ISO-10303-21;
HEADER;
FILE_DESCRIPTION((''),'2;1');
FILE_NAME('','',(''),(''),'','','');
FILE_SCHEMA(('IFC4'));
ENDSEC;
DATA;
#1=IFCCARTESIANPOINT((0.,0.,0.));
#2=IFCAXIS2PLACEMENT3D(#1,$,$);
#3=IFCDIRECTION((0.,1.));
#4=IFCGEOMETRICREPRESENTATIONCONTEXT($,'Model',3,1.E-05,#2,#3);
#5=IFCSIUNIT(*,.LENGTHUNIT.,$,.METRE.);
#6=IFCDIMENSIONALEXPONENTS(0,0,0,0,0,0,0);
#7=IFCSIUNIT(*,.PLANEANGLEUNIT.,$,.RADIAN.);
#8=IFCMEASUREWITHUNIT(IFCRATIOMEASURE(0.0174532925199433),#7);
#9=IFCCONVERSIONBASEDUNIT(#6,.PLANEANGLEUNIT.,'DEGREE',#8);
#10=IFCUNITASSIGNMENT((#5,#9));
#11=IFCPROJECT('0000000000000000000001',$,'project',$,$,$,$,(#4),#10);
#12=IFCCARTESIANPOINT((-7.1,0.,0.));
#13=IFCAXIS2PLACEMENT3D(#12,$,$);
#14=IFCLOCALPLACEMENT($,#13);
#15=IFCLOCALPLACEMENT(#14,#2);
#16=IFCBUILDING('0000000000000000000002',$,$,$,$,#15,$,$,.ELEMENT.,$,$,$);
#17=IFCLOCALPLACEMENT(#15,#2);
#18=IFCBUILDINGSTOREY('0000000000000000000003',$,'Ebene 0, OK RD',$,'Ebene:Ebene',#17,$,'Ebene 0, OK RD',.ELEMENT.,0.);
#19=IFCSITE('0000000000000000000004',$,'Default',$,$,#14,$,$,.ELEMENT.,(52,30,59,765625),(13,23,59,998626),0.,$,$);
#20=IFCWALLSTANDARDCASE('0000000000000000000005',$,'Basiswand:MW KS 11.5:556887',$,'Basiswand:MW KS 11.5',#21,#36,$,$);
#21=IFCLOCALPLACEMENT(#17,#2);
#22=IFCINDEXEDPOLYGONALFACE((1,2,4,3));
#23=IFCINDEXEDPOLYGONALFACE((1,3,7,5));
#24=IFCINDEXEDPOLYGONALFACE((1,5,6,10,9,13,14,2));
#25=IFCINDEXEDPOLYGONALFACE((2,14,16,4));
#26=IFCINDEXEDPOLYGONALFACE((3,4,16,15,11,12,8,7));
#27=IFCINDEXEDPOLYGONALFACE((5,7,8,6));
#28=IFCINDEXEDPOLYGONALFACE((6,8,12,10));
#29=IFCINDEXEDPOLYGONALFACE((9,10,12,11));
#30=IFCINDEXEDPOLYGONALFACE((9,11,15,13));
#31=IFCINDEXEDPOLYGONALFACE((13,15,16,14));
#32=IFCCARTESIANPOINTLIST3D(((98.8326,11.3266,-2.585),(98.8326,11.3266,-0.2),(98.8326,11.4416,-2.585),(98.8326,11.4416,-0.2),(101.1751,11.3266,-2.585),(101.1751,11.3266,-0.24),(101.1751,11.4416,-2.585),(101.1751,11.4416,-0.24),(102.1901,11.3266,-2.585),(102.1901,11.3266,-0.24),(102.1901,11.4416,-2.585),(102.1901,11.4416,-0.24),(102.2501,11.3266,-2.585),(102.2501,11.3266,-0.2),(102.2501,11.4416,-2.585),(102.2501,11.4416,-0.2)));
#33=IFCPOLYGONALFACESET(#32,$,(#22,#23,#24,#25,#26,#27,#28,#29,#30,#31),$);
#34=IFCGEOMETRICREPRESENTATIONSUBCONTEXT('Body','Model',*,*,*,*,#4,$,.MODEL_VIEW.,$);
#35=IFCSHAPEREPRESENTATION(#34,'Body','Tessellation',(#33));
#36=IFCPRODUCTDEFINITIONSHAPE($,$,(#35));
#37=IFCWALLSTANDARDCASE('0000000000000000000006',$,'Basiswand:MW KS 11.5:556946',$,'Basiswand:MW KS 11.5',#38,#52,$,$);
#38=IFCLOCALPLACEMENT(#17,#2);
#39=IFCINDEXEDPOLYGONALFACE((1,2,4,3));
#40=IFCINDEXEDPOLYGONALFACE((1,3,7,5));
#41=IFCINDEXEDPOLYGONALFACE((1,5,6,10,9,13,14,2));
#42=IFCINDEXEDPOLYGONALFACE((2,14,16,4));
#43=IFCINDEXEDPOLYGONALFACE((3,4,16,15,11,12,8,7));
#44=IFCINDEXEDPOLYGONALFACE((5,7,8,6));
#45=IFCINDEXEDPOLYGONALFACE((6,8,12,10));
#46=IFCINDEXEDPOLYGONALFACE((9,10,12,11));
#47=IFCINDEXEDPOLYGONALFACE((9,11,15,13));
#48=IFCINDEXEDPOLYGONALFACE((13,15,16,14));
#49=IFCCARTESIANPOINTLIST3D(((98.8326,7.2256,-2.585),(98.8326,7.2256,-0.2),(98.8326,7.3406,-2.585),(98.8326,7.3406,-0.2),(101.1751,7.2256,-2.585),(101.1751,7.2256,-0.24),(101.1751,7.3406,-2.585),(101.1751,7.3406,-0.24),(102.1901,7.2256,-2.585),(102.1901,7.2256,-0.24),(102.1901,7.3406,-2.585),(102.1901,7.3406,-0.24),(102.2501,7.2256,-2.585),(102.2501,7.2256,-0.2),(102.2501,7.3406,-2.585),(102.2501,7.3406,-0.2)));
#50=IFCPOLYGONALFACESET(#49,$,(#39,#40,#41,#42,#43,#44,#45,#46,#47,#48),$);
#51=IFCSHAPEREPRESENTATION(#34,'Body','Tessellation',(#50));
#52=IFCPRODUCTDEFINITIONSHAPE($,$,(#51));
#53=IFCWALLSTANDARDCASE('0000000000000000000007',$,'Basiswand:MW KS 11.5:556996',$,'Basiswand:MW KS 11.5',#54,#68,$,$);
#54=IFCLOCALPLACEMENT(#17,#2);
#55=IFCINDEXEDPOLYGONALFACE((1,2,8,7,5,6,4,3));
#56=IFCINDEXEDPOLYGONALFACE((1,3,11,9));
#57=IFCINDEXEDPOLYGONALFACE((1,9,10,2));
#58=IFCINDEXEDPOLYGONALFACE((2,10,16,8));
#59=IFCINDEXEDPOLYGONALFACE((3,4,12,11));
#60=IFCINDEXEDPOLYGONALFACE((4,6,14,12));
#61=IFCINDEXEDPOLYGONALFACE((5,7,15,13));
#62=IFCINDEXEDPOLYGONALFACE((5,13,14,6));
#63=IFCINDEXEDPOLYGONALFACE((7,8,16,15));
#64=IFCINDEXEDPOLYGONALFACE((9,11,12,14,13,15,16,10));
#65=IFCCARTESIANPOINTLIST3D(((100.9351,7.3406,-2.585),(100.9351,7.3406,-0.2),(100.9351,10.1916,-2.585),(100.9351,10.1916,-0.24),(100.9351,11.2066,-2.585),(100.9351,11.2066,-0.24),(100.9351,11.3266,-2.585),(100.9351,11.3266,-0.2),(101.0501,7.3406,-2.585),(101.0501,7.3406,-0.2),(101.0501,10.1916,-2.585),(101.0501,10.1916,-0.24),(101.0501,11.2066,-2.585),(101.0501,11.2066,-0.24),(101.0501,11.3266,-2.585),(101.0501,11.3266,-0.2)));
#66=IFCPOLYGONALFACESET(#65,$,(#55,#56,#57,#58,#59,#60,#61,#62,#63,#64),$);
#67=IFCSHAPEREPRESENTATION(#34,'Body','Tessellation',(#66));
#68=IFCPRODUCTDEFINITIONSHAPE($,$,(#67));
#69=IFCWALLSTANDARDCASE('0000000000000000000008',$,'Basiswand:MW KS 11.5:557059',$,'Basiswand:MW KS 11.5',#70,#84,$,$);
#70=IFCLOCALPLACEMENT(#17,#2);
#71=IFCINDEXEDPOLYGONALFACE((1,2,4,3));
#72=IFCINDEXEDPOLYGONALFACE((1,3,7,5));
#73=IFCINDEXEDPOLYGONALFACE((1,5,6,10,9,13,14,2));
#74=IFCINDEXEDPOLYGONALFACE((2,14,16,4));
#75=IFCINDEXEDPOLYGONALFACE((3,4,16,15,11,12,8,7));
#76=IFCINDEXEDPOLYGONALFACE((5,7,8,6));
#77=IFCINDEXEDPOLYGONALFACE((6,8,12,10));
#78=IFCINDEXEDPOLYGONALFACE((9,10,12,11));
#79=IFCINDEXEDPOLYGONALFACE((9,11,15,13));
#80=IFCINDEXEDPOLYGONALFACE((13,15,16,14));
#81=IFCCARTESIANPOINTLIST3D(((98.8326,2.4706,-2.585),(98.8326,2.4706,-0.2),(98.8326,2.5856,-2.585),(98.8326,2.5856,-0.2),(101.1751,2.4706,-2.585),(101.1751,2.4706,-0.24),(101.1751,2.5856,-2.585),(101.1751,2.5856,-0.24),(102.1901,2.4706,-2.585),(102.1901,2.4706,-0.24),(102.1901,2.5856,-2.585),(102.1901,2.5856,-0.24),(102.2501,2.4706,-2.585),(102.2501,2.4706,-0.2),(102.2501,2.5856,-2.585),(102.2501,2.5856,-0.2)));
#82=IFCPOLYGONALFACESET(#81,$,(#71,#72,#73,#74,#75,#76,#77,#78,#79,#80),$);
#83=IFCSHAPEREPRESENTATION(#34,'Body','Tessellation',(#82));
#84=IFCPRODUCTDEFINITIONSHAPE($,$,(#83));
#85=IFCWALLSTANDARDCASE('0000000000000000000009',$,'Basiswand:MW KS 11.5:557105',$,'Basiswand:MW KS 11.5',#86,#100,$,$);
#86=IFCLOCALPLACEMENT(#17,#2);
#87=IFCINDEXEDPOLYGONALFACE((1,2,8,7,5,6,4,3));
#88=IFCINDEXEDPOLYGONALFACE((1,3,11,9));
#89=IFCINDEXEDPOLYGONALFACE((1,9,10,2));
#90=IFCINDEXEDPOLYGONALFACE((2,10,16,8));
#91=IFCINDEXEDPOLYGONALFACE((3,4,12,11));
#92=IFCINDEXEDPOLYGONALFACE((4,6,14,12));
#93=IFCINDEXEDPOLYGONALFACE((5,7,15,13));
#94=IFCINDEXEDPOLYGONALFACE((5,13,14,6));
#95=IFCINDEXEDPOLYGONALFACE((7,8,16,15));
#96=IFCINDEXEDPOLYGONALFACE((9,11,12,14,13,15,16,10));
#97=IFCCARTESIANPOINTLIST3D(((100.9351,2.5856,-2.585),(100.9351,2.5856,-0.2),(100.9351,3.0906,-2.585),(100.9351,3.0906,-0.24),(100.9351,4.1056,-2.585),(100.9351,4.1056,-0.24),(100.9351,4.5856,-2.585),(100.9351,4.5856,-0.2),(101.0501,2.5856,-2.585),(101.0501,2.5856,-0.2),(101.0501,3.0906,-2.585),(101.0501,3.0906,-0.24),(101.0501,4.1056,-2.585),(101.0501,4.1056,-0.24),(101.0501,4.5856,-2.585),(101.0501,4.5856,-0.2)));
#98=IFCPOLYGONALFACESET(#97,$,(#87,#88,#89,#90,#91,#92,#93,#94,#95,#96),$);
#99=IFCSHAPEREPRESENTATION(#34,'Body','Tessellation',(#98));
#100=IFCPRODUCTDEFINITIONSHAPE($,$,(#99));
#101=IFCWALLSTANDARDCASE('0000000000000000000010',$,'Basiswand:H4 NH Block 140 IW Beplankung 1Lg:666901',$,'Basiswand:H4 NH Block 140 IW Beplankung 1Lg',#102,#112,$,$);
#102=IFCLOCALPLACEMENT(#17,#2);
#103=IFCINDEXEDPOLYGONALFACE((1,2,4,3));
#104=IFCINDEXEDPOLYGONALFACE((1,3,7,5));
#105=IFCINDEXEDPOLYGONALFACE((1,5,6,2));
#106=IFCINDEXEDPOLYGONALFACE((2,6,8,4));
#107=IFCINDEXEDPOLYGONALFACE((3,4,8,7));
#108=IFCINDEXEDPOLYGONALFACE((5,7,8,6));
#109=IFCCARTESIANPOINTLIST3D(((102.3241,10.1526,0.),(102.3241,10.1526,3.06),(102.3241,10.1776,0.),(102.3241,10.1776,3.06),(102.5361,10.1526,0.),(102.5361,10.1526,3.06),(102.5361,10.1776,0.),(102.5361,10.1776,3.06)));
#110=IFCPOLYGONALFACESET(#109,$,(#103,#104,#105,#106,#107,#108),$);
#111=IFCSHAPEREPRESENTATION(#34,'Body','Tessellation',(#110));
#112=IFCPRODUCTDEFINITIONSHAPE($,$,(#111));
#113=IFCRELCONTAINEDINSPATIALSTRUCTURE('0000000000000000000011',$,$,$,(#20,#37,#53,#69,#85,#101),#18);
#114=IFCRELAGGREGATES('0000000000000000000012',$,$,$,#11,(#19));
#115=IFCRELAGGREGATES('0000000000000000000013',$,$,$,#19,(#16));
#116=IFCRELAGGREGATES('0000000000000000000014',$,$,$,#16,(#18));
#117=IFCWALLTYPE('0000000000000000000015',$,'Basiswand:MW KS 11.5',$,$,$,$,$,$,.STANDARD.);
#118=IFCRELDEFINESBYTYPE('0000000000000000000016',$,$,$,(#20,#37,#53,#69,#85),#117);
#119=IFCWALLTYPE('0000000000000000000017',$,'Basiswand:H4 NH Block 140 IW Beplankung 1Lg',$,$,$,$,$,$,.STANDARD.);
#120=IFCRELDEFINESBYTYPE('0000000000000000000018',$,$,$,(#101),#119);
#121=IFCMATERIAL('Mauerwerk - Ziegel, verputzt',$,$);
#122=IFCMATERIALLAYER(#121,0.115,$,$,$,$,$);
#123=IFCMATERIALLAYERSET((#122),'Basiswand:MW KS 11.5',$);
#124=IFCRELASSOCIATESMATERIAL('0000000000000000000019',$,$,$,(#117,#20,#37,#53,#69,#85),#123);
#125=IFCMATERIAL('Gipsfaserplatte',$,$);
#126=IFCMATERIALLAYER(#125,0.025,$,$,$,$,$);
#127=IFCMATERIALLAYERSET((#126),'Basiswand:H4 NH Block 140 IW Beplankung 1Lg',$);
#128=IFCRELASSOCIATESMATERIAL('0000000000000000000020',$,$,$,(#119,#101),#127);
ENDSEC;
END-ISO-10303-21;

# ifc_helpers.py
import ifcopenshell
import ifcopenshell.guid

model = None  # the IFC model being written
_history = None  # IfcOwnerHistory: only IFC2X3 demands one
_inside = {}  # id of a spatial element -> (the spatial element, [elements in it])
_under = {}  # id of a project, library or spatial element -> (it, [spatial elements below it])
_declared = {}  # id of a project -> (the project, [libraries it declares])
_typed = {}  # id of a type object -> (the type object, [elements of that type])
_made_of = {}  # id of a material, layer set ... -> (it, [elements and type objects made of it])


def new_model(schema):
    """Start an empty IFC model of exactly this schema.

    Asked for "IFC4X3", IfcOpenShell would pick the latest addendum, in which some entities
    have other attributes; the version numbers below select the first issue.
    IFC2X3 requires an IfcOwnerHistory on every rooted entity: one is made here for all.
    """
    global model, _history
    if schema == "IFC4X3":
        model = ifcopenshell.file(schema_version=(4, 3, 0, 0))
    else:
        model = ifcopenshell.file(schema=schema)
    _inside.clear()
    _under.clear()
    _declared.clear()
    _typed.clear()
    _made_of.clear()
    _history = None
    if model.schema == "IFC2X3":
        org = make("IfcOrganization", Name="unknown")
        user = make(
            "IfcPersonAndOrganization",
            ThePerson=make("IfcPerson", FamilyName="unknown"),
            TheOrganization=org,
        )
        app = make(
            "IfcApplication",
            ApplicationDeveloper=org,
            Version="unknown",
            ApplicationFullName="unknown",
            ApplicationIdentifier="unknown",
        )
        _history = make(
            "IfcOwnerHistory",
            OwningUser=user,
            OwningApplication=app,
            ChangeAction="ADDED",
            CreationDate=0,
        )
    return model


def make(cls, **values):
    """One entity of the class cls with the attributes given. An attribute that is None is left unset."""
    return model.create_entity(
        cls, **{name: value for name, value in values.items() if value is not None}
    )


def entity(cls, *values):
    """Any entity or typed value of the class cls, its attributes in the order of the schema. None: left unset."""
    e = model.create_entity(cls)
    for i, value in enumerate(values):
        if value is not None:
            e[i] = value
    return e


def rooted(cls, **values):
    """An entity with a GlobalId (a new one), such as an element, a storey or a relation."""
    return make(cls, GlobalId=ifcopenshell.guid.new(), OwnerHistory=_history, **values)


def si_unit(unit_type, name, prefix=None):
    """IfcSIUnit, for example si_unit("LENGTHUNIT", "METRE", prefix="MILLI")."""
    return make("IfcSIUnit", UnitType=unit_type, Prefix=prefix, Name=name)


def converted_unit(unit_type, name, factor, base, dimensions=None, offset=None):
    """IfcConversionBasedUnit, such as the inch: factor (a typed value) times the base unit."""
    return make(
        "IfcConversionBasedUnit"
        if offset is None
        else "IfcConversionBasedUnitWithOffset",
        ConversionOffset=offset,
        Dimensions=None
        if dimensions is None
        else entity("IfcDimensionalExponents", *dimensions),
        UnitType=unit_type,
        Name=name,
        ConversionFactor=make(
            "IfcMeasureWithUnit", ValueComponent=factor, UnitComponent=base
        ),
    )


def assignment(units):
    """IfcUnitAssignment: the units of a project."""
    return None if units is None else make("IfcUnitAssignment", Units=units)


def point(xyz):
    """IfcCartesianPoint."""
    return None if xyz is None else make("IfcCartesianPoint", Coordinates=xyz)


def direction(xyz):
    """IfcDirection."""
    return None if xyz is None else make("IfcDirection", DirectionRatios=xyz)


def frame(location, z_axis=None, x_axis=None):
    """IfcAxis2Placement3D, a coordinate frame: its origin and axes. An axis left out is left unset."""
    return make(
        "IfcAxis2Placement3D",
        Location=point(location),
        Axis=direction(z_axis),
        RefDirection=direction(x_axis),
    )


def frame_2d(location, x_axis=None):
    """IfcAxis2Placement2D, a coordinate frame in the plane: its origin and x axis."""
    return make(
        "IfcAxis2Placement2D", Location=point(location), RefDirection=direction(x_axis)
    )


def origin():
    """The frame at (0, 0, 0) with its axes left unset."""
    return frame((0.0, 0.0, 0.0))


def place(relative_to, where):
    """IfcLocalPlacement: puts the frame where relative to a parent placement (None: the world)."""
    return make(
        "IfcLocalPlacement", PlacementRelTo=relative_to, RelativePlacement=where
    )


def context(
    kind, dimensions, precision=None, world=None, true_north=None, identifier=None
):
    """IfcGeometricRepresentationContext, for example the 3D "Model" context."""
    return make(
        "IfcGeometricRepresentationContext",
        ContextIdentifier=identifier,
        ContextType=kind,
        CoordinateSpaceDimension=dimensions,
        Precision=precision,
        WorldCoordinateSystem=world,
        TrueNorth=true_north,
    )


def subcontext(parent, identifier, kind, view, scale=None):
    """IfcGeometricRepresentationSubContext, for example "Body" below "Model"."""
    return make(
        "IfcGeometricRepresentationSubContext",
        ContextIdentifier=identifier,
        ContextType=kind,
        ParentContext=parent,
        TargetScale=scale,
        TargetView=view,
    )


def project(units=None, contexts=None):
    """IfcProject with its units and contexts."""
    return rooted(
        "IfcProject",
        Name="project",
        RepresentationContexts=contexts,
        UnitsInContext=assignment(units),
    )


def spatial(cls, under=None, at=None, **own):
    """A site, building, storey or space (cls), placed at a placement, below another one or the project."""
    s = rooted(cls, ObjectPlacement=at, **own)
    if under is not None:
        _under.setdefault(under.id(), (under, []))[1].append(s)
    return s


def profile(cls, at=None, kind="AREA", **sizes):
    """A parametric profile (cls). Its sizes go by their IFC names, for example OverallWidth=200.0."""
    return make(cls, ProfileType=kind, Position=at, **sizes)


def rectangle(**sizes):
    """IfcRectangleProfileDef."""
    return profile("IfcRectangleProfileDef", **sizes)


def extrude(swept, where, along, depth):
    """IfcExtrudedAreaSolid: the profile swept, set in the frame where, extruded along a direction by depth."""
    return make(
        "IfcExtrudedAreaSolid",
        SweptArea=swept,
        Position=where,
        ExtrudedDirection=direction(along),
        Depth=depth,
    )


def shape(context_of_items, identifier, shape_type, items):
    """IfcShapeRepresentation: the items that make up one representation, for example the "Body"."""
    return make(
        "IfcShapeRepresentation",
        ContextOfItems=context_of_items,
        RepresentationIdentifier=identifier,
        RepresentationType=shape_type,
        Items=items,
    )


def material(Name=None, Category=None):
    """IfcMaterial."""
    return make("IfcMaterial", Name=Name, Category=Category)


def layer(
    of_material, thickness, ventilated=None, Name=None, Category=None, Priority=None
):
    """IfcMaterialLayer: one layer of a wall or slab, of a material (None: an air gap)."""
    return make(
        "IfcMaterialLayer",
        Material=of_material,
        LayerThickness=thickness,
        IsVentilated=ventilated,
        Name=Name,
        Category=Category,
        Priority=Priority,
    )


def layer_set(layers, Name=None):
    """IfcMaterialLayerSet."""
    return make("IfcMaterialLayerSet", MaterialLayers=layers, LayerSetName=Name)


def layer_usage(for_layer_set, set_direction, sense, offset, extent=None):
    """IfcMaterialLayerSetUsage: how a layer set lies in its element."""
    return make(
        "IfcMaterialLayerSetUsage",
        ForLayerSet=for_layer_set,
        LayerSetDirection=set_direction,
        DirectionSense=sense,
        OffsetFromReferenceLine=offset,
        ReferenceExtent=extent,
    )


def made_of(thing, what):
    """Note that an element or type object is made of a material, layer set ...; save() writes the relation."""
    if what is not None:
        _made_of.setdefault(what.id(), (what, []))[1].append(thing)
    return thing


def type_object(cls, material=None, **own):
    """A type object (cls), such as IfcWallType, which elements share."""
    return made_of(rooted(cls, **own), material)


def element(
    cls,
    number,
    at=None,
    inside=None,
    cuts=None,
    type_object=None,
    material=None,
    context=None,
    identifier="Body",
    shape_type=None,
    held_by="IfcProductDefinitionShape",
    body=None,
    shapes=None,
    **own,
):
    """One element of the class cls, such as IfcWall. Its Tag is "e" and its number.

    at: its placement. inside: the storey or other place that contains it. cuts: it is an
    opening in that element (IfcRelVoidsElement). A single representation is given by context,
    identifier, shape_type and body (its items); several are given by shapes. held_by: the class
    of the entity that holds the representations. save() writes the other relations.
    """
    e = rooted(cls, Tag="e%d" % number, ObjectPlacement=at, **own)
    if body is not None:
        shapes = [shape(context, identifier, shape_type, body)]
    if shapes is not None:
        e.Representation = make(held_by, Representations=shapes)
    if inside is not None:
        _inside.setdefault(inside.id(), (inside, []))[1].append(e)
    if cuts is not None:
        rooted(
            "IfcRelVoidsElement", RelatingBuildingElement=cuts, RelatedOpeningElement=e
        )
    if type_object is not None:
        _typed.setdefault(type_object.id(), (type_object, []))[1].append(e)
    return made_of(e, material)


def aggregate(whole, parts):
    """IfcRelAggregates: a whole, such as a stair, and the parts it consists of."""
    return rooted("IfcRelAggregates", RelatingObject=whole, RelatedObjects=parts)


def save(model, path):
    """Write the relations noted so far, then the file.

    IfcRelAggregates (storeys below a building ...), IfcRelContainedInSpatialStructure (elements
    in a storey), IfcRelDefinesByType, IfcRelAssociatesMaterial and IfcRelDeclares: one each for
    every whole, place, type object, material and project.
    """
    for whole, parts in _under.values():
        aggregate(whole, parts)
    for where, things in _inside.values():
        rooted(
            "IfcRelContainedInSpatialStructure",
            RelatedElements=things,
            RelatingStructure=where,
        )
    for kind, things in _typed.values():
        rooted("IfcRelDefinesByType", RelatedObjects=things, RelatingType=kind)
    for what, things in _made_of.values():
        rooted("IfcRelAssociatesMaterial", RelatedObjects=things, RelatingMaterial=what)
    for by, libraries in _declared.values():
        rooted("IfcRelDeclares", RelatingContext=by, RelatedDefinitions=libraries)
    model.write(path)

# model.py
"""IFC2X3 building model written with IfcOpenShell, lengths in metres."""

from ifc_helpers import new_model, entity, si_unit, converted_unit, direction, frame, frame_2d, origin, place, context, subcontext, project, spatial, rectangle, extrude, material, layer, layer_set, layer_usage, type_object, element, save


model = new_model("IFC2X3")

# Units and contexts
model_context = context("Model", 3, precision=1e-05, world=origin(), true_north=direction((0.0, 1.0)))
body_context = subcontext(model_context, "Body", "Model", "MODEL_VIEW")
ifc_project = project(units=[si_unit("LENGTHUNIT", "METRE"), converted_unit("PLANEANGLEUNIT", "DEGREE", entity("IfcRatioMeasure", 0.0174532925199433), si_unit("PLANEANGLEUNIT", "RADIAN"), dimensions=[0, 0, 0, 0, 0, 0, 0])], contexts=[model_context])

# Site, building, storey
site_placement = place(None, frame((-7.1, 0.0, 0.0)))
site = spatial("IfcSite", under=ifc_project, at=site_placement, Name="Default", CompositionType="ELEMENT", RefLatitude=(52, 30, 59, 765625), RefLongitude=(13, 23, 59, 998626), RefElevation=0.0)
building_placement = place(site_placement, origin())
building = spatial("IfcBuilding", under=site, at=building_placement, CompositionType="ELEMENT")
storey_placement = place(building_placement, origin())
storey = spatial("IfcBuildingStorey", under=building, at=storey_placement, Name="Ebene 0, OK RD", ObjectType="Ebene:Ebene", LongName="Ebene 0, OK RD", CompositionType="ELEMENT", Elevation=0.0)

# Shared definitions
ifc_material_1 = material(Name="Gipsfaserplatte")

# Walls, openings
ifc_material_2 = material(Name="Mauerwerk - Ziegel, verputzt")
ifc_layer_1 = layer(ifc_material_2, 0.115)
ifc_layer_set_1 = layer_set([ifc_layer_1], Name="Basiswand:MW KS 11.5")
ifc_layer_usage_1 = layer_usage(ifc_layer_set_1, "AXIS2", "NEGATIVE", 0.0575)
wall_type_1 = type_object("IfcWallType", Name="Basiswand:MW KS 11.5", PredefinedType="STANDARD", material=ifc_layer_set_1)
wall_1_placement = place(storey_placement, frame((102.2501, 11.3841, -2.585), z_axis=(0.0, 0.0, 1.0), x_axis=(-1.0, 0.0, 0.0)))
wall_1 = element("IfcWallStandardCase", 1, at=wall_1_placement, inside=storey, type_object=wall_type_1, material=ifc_layer_usage_1, Name="Basiswand:MW KS 11.5:556887", ObjectType="Basiswand:MW KS 11.5", context=body_context, shape_type="SweptSolid", body=[
    extrude(rectangle(XDim=3.4175, YDim=0.115, at=frame_2d((1.7087, 0.0), x_axis=(-1.0, 0.0))), origin(), (0.0, 0.0, 1.0), 2.385),
])
opening_1_placement = place(wall_1_placement, frame((1.075, 0.0575, 0.0)))
element("IfcOpeningElement", 2, at=opening_1_placement, cuts=wall_1, ObjectType="Opening", context=body_context, shape_type="SweptSolid", body=[
    extrude(rectangle(XDim=2.345, YDim=1.015, at=frame_2d((1.1725, 0.5075), x_axis=(1.0, 0.0))), frame((0.0, 0.0, 0.0), z_axis=(0.0, -1.0, 0.0), x_axis=(0.0, 0.0, 1.0)), (0.0, 0.0, 1.0), 0.115),
])
ifc_layer_usage_2 = layer_usage(ifc_layer_set_1, "AXIS2", "NEGATIVE", 0.0575)
wall_2_placement = place(storey_placement, frame((102.2501, 7.2831, -2.585), z_axis=(0.0, 0.0, 1.0), x_axis=(-1.0, 0.0, 0.0)))
wall_2 = element("IfcWallStandardCase", 3, at=wall_2_placement, inside=storey, type_object=wall_type_1, material=ifc_layer_usage_2, Name="Basiswand:MW KS 11.5:556946", ObjectType="Basiswand:MW KS 11.5", context=body_context, shape_type="SweptSolid", body=[
    extrude(rectangle(XDim=3.4175, YDim=0.115, at=frame_2d((1.7087, 0.0), x_axis=(-1.0, 0.0))), origin(), (0.0, 0.0, 1.0), 2.385),
])
opening_2_placement = place(wall_2_placement, frame((0.06, -0.0575, 0.0)))
element("IfcOpeningElement", 4, at=opening_2_placement, cuts=wall_2, ObjectType="Opening", context=body_context, shape_type="SweptSolid", body=[
    extrude(rectangle(XDim=2.345, YDim=1.015, at=frame_2d((1.1725, 0.5075), x_axis=(1.0, 0.0))), frame((0.0, 0.0, 0.0), z_axis=(0.0, 1.0, 0.0), x_axis=(0.0, 0.0, 1.0)), (0.0, 0.0, 1.0), 0.115),
])
ifc_layer_usage_3 = layer_usage(ifc_layer_set_1, "AXIS2", "NEGATIVE", 0.0575)
wall_3_placement = place(storey_placement, frame((100.9926, 7.3406, -2.585), z_axis=(0.0, 0.0, 1.0), x_axis=(0.0, 1.0, 0.0)))
wall_3 = element("IfcWallStandardCase", 5, at=wall_3_placement, inside=storey, type_object=wall_type_1, material=ifc_layer_usage_3, Name="Basiswand:MW KS 11.5:556996", ObjectType="Basiswand:MW KS 11.5", context=body_context, shape_type="SweptSolid", body=[
    extrude(rectangle(XDim=3.986, YDim=0.115, at=frame_2d((1.993, 0.0), x_axis=(-1.0, 0.0))), origin(), (0.0, 0.0, 1.0), 2.385),
])
opening_3_placement = place(wall_3_placement, frame((2.851, -0.0575, 0.0)))
element("IfcOpeningElement", 6, at=opening_3_placement, cuts=wall_3, ObjectType="Opening", context=body_context, shape_type="SweptSolid", body=[
    extrude(rectangle(XDim=2.345, YDim=1.015, at=frame_2d((1.1725, 0.5075), x_axis=(1.0, 0.0))), frame((0.0, 0.0, 0.0), z_axis=(0.0, 1.0, 0.0), x_axis=(0.0, 0.0, 1.0)), (0.0, 0.0, 1.0), 0.115),
])
ifc_layer_usage_4 = layer_usage(ifc_layer_set_1, "AXIS2", "POSITIVE", -0.0575)
wall_4_placement = place(storey_placement, frame((102.2501, 2.5281, -2.585), z_axis=(0.0, 0.0, 1.0), x_axis=(-1.0, 0.0, 0.0)))
wall_4 = element("IfcWallStandardCase", 7, at=wall_4_placement, inside=storey, type_object=wall_type_1, material=ifc_layer_usage_4, Name="Basiswand:MW KS 11.5:557059", ObjectType="Basiswand:MW KS 11.5", context=body_context, shape_type="SweptSolid", body=[
    extrude(rectangle(XDim=3.4175, YDim=0.115, at=frame_2d((1.7087, 0.0), x_axis=(-1.0, 0.0))), origin(), (0.0, 0.0, 1.0), 2.385),
])
opening_4_placement = place(wall_4_placement, frame((0.06, -0.0575, 0.0)))
element("IfcOpeningElement", 8, at=opening_4_placement, cuts=wall_4, ObjectType="Opening", context=body_context, shape_type="SweptSolid", body=[
    extrude(rectangle(XDim=2.345, YDim=1.015, at=frame_2d((1.1725, 0.5075), x_axis=(1.0, 0.0))), frame((0.0, 0.0, 0.0), z_axis=(0.0, 1.0, 0.0), x_axis=(0.0, 0.0, 1.0)), (0.0, 0.0, 1.0), 0.115),
])
ifc_layer_usage_5 = layer_usage(ifc_layer_set_1, "AXIS2", "NEGATIVE", 0.0575)
wall_5_placement = place(storey_placement, frame((100.9926, 2.5856, -2.585), z_axis=(0.0, 0.0, 1.0), x_axis=(0.0, 1.0, 0.0)))
wall_5 = element("IfcWallStandardCase", 9, at=wall_5_placement, inside=storey, type_object=wall_type_1, material=ifc_layer_usage_5, Name="Basiswand:MW KS 11.5:557105", ObjectType="Basiswand:MW KS 11.5", context=body_context, shape_type="SweptSolid", body=[
    extrude(rectangle(XDim=2.0, YDim=0.115, at=frame_2d((1.0, 0.0), x_axis=(-1.0, 0.0))), origin(), (0.0, 0.0, 1.0), 2.385),
])
opening_5_placement = place(wall_5_placement, frame((0.505, -0.0575, 0.0)))
element("IfcOpeningElement", 10, at=opening_5_placement, cuts=wall_5, ObjectType="Opening", context=body_context, shape_type="SweptSolid", body=[
    extrude(rectangle(XDim=2.345, YDim=1.015, at=frame_2d((1.1725, 0.5075), x_axis=(1.0, 0.0))), frame((0.0, 0.0, 0.0), z_axis=(0.0, 1.0, 0.0), x_axis=(0.0, 0.0, 1.0)), (0.0, 0.0, 1.0), 0.115),
])

# Wall
ifc_layer_2 = layer(ifc_material_1, 0.025)
ifc_layer_set_2 = layer_set([ifc_layer_2], Name="Basiswand:H4 NH Block 140 IW Beplankung 1Lg")
ifc_layer_usage_6 = layer_usage(ifc_layer_set_2, "AXIS2", "NEGATIVE", 0.0125)
wall_type_2 = type_object("IfcWallType", Name="Basiswand:H4 NH Block 140 IW Beplankung 1Lg", PredefinedType="STANDARD", material=ifc_layer_set_2)
wall_6_placement = place(storey_placement, frame((102.3241, 10.1651, 0.0)))
element("IfcWallStandardCase", 11, at=wall_6_placement, inside=storey, type_object=wall_type_2, material=ifc_layer_usage_6, Name="Basiswand:H4 NH Block 140 IW Beplankung 1Lg:666901", ObjectType="Basiswand:H4 NH Block 140 IW Beplankung 1Lg", context=body_context, shape_type="SweptSolid", body=[
    extrude(rectangle(XDim=0.212, YDim=0.025, at=frame_2d((0.106, 0.0), x_axis=(-1.0, 0.0))), origin(), (0.0, 0.0, 1.0), 3.06),
])

save(model, "model.ifc")
